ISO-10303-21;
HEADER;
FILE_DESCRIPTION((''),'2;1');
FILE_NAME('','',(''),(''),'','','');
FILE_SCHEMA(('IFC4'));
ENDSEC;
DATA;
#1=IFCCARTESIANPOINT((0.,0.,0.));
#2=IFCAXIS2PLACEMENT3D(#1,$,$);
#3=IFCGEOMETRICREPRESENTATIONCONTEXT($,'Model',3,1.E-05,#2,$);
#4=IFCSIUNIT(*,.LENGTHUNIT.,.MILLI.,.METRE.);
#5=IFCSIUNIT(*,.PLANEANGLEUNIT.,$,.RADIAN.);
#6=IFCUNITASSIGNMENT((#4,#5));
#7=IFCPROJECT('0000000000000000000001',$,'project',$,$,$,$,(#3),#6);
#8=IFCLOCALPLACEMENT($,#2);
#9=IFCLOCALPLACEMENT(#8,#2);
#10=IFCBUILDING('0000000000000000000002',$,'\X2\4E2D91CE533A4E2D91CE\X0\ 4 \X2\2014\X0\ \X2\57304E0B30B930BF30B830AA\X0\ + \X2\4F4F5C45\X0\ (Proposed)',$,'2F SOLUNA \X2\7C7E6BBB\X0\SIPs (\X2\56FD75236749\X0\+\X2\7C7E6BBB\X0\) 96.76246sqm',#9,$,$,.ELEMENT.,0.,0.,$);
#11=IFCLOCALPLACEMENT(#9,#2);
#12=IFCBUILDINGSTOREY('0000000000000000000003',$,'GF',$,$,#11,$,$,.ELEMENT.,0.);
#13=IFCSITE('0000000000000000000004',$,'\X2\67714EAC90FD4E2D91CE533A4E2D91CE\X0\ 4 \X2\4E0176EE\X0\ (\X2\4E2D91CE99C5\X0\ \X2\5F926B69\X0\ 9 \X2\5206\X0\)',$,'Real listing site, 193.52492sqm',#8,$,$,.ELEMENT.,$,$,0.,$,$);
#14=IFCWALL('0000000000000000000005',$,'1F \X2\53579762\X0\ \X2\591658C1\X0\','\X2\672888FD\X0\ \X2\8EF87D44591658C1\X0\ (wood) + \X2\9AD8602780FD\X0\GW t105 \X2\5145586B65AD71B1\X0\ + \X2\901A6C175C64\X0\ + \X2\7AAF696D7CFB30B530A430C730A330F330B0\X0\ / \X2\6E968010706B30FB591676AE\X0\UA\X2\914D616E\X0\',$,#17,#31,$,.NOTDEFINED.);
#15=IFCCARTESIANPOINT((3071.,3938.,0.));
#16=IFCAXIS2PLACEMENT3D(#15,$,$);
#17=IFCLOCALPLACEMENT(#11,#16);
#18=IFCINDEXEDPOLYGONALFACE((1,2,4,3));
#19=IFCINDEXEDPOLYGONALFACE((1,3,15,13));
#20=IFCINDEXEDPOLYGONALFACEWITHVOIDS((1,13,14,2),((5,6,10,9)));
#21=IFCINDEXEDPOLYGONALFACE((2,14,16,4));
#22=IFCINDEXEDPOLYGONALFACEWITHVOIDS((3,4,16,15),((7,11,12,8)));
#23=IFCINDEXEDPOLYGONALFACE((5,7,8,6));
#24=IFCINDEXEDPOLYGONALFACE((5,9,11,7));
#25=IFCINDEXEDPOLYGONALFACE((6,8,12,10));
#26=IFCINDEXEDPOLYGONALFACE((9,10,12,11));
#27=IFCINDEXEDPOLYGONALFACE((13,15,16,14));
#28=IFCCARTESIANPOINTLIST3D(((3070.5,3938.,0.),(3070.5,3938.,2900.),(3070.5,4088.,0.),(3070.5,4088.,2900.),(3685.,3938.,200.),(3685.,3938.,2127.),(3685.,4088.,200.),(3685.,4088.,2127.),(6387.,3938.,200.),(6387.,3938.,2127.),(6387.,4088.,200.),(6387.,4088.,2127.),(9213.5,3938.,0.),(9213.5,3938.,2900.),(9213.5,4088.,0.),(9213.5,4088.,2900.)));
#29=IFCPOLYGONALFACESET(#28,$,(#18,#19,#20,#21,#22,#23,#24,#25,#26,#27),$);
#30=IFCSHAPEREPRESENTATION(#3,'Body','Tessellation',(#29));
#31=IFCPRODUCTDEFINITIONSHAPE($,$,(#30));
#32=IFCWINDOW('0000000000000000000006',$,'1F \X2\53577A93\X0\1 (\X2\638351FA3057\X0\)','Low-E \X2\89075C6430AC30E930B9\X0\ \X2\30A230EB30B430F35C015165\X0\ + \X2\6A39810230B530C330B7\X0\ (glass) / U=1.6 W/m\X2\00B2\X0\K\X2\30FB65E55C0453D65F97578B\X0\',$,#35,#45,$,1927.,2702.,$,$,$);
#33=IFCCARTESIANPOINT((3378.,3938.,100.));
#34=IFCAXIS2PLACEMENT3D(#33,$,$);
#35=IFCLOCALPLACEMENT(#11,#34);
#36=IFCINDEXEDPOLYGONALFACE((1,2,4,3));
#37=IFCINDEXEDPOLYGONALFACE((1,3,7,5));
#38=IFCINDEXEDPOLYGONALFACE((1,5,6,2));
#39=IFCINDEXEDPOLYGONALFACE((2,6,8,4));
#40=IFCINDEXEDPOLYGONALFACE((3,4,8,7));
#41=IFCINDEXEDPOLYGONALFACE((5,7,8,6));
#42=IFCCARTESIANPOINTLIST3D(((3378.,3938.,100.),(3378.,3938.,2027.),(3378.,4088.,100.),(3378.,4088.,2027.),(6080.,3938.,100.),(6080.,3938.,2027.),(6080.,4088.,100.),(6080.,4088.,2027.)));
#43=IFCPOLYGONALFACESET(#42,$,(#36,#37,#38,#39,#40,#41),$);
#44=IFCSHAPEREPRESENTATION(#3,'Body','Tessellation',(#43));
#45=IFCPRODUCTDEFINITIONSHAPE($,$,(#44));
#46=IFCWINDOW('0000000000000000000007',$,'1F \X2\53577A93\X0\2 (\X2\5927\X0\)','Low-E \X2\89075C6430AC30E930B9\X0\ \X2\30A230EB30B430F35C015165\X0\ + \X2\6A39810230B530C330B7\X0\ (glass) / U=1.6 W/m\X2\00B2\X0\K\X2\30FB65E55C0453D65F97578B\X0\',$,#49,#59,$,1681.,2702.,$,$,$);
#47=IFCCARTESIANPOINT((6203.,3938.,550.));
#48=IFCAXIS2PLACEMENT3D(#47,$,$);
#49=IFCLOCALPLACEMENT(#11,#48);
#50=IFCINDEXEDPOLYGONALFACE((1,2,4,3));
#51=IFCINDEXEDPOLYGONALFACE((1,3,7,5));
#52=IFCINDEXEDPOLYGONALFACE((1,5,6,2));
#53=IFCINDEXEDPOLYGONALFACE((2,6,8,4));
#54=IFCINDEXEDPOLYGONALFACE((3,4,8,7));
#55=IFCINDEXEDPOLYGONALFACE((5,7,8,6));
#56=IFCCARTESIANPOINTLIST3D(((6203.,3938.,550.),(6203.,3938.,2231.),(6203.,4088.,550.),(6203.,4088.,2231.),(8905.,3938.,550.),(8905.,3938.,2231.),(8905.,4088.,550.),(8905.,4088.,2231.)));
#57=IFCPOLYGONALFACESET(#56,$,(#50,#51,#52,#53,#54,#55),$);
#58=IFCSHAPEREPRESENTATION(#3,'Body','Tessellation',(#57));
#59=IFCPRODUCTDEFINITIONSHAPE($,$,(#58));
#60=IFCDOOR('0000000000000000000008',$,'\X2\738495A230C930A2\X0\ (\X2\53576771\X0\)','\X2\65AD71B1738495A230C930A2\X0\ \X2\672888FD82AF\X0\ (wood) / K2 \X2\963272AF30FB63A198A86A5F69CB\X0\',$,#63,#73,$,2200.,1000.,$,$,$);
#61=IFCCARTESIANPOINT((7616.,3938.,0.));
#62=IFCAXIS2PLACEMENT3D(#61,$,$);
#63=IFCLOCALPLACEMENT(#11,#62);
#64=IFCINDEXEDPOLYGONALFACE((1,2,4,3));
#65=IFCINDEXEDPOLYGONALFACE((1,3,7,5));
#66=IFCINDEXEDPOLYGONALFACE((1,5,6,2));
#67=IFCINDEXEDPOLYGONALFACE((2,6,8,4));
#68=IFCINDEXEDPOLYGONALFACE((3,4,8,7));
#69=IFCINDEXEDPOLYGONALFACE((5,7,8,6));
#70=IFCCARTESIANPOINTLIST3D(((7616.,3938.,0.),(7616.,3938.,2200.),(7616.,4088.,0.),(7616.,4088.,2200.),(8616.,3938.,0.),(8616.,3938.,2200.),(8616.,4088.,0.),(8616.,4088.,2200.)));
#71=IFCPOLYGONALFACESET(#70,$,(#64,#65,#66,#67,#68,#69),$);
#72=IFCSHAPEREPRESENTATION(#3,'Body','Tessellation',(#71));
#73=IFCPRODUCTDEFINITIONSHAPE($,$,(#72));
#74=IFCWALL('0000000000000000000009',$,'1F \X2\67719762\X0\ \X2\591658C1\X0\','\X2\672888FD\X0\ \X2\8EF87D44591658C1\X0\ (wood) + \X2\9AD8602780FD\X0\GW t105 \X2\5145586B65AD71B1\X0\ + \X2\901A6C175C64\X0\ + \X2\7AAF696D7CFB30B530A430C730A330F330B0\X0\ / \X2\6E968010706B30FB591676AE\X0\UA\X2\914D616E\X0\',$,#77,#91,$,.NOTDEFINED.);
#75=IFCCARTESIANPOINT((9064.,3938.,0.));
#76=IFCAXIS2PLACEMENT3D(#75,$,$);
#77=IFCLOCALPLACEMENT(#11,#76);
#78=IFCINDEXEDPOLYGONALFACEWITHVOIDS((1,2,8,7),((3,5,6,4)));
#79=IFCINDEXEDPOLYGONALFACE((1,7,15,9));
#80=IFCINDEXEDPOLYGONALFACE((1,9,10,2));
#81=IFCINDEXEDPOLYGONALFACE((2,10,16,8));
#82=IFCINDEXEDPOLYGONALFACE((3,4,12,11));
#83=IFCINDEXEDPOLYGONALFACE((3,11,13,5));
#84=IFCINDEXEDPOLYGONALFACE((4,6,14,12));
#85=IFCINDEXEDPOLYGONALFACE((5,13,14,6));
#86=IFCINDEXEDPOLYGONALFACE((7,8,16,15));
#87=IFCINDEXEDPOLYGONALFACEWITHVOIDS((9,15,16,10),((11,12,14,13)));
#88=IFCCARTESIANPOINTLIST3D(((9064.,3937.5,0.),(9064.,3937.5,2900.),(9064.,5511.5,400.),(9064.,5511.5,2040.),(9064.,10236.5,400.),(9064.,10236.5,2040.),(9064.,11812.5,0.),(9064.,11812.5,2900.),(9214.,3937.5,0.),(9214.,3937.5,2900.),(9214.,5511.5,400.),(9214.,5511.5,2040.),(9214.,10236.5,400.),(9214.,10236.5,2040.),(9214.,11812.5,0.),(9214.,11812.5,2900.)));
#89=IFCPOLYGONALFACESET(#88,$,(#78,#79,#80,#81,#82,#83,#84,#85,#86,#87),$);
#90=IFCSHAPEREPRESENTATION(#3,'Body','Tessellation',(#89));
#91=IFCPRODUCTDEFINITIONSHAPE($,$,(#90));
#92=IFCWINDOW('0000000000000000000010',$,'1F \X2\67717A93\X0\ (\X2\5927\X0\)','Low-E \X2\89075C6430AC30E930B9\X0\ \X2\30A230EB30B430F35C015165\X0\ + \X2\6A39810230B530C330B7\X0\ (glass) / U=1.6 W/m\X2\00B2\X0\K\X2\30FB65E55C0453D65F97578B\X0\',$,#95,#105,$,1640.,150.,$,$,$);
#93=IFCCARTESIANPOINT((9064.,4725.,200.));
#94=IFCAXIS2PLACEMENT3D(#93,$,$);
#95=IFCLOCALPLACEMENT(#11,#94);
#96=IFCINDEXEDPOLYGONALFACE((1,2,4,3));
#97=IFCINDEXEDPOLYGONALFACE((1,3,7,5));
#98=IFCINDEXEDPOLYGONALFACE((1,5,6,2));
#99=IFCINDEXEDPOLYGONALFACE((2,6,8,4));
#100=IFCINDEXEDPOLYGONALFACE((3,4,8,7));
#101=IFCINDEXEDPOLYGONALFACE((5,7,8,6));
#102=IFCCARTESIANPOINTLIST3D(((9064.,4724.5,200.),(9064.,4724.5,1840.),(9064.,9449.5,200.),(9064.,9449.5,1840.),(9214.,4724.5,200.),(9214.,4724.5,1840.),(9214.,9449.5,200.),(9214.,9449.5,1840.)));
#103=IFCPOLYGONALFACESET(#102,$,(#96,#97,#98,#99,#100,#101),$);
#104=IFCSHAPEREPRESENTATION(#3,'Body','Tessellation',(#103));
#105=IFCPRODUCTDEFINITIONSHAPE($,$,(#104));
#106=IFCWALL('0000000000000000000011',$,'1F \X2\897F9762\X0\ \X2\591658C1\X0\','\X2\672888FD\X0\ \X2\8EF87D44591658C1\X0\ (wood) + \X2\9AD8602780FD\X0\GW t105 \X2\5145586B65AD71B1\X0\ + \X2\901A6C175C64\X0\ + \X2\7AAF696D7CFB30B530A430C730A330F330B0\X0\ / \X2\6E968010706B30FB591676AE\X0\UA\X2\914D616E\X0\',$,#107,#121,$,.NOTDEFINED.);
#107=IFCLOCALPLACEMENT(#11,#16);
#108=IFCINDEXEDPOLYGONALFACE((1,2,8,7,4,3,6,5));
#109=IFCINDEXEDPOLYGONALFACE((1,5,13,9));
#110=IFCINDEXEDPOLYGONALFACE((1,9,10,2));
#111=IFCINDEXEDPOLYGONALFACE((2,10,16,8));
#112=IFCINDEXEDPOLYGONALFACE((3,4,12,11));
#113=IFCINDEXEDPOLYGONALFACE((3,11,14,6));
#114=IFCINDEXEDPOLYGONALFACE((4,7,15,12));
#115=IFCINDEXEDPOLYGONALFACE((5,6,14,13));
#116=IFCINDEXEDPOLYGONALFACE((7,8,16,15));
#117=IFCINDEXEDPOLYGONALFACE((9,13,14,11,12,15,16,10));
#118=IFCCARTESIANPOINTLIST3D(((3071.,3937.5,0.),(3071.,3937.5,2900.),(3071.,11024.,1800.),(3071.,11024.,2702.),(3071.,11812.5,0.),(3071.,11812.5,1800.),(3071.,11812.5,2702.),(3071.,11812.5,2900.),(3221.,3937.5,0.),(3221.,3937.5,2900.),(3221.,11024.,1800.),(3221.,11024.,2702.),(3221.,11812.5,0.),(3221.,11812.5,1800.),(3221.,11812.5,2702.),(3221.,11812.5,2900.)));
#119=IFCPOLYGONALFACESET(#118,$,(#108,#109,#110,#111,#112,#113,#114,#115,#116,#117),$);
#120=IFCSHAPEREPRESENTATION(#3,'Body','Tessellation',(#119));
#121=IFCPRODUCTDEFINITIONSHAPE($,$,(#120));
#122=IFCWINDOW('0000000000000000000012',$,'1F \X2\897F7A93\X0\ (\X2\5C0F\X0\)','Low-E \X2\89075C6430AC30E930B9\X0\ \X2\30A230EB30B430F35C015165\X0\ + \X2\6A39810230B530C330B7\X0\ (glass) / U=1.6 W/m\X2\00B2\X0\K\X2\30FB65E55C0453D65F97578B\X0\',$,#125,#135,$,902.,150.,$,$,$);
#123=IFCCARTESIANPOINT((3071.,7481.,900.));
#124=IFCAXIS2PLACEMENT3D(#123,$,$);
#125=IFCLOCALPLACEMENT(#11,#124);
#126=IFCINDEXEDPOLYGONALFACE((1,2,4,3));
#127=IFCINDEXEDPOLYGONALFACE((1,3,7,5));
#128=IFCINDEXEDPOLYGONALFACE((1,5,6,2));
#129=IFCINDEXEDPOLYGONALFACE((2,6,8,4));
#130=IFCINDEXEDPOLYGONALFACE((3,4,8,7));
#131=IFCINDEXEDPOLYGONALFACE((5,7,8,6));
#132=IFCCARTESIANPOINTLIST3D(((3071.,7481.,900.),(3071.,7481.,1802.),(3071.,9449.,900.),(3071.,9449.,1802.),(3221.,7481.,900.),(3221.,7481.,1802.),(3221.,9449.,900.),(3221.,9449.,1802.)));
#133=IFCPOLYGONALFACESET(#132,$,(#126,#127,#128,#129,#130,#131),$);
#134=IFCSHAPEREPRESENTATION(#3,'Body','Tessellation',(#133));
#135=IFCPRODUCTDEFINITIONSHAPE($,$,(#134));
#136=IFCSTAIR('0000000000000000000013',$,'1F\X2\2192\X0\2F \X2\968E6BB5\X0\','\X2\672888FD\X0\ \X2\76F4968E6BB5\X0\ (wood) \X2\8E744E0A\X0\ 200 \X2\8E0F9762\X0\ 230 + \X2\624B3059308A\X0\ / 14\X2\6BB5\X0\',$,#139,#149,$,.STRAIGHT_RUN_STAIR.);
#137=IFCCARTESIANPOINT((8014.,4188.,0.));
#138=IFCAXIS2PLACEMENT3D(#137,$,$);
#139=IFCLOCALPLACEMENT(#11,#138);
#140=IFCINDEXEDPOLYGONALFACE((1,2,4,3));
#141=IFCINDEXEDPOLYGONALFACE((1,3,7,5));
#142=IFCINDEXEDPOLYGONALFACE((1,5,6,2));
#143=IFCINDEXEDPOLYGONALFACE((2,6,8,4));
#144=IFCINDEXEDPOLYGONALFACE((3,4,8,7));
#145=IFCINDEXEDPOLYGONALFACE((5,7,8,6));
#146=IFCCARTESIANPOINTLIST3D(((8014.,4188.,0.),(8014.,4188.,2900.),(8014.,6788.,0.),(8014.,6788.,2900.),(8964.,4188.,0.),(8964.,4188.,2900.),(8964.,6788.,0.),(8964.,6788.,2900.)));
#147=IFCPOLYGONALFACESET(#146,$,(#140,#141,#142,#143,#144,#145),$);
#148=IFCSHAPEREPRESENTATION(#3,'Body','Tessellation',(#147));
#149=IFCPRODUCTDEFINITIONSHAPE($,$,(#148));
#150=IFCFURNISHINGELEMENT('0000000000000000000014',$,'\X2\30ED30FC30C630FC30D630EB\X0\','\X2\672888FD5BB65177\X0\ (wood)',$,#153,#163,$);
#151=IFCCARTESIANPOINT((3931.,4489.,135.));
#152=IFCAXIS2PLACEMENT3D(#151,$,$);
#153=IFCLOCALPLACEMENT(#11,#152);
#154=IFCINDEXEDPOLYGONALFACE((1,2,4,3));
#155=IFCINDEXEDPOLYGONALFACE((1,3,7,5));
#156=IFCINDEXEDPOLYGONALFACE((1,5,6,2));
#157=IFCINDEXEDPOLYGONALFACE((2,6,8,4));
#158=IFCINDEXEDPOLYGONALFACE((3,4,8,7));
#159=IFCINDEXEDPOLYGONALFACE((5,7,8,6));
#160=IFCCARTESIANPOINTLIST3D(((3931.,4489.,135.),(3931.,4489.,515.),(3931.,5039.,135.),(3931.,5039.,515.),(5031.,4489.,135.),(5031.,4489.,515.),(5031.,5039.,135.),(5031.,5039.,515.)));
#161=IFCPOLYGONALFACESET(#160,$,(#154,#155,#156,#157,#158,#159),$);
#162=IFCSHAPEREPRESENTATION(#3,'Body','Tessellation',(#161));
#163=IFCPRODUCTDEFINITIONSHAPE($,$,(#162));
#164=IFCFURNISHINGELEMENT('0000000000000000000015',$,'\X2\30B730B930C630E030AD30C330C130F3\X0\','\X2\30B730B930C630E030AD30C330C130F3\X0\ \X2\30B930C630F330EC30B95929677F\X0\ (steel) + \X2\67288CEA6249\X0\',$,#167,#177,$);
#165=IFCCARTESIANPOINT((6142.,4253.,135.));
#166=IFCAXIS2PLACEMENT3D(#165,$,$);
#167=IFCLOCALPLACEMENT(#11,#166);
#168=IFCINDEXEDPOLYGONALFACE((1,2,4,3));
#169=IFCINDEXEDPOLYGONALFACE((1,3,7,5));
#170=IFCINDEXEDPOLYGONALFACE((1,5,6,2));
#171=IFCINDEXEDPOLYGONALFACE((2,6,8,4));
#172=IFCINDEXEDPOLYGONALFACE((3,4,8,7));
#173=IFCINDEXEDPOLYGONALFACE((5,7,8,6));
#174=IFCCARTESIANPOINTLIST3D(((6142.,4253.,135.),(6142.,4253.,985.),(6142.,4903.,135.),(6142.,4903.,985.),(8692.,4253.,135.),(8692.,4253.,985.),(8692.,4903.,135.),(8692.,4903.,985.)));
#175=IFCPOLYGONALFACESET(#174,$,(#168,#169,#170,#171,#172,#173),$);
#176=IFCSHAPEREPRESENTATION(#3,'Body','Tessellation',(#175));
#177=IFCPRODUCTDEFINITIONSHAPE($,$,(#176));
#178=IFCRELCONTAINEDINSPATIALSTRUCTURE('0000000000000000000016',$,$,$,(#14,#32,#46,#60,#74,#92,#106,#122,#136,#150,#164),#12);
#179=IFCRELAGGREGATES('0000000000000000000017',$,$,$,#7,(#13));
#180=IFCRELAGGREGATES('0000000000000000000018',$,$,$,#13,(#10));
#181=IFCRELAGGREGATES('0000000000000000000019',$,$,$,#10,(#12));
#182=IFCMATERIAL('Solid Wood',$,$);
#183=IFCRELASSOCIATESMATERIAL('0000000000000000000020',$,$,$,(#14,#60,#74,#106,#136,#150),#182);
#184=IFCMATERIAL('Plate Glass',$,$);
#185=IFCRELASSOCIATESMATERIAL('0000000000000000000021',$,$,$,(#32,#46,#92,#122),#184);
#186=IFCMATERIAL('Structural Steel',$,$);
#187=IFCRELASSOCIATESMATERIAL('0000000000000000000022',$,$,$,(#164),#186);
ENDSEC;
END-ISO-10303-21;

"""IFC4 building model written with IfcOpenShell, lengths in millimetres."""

from ifc_helpers import new_model, si_unit, frame, frame_2d, origin, place, context, project, spatial, rectangle, extrude, material, element, fill, save


model = new_model("IFC4")

# Units and contexts
model_context = context("Model", 3, precision=1e-05, world=origin())
ifc_project = project(units=[si_unit("LENGTHUNIT", "METRE", prefix="MILLI"), si_unit("PLANEANGLEUNIT", "RADIAN")], contexts=[model_context])

# Site, building, storey
site_placement = place(None, origin())
site = spatial("IfcSite", under=ifc_project, at=site_placement, Name="東京都中野区中野 4 丁目 (中野駅 徒歩 9 分)", ObjectType="Real listing site, 193.52492sqm", CompositionType="ELEMENT", RefElevation=0.0)
building_placement = place(site_placement, origin())
building = spatial("IfcBuilding", under=site, at=building_placement, Name="中野区中野 4 — 地下スタジオ + 住居 (Proposed)", ObjectType="2F SOLUNA 籾殻SIPs (国産杉+籾殻) 96.76246sqm", CompositionType="ELEMENT", ElevationOfRefHeight=0.0, ElevationOfTerrain=0.0)
storey_placement = place(building_placement, origin())
storey = spatial("IfcBuildingStorey", under=building, at=storey_placement, Name="GF", CompositionType="ELEMENT", Elevation=0.0)

# Shared definitions
ifc_material_1 = material(Name="Solid Wood")

# Wall, openings, windows, door
wall_1_placement = place(storey_placement, frame((3071.0, 3938.0, 0.0)))
wall_1 = element("IfcWall", 1, at=wall_1_placement, inside=storey, material=ifc_material_1, Name="1F 南面 外壁", Description="木製 軸組外壁 (wood) + 高性能GW t105 充填断熱 + 通気層 + 窯業系サイディング / 準耐火・外皮UA配慮", PredefinedType="NOTDEFINED", context=model_context, shape_type="SweptSolid", body=[
    extrude(rectangle(XDim=6143.0, YDim=150.0, at=frame_2d((3071.0, 75.0))), frame((3071.0, 3938.0, 0.0)), (0.0, 0.0, 1.0), 2900.0),
])
opening_1_placement = place(storey_placement, frame((3378.0, 3938.0, 100.0)))
opening_1 = element("IfcOpeningElement", 2, at=opening_1_placement, cuts=wall_1, PredefinedType="NOTDEFINED", context=model_context, shape_type="SweptSolid", body=[
    extrude(rectangle(XDim=2702.0, YDim=150.0, at=frame_2d((1351.0, 75.0))), frame((3378.0, 3938.0, 100.0)), (0.0, 0.0, 1.0), 1927.0),
])
opening_2_placement = place(storey_placement, frame((6203.0, 3938.0, 550.0)))
opening_2 = element("IfcOpeningElement", 3, at=opening_2_placement, cuts=wall_1, PredefinedType="NOTDEFINED", context=model_context, shape_type="SweptSolid", body=[
    extrude(rectangle(XDim=2702.0, YDim=150.0, at=frame_2d((1351.0, 75.0))), frame((6203.0, 3938.0, 550.0)), (0.0, 0.0, 1.0), 1681.0),
])
opening_3_placement = place(storey_placement, frame((7616.0, 3938.0, 0.0)))
opening_3 = element("IfcOpeningElement", 4, at=opening_3_placement, cuts=wall_1, PredefinedType="NOTDEFINED", context=model_context, shape_type="SweptSolid", body=[
    extrude(rectangle(XDim=1000.0, YDim=150.0, at=frame_2d((500.0, 75.0))), frame((7616.0, 3938.0, 0.0)), (0.0, 0.0, 1.0), 2200.0),
])
ifc_material_2 = material(Name="Plate Glass")
window_1_placement = place(storey_placement, frame((3378.0, 3938.0, 100.0)))
window_1 = element("IfcWindow", 5, at=window_1_placement, inside=storey, material=ifc_material_2, Name="1F 南窓1 (掃出し)", Description="Low-E 複層ガラス アルゴン封入 + 樹脂サッシ (glass) / U=1.6 W/m²K・日射取得型", OverallHeight=1927.0, OverallWidth=2702.0, context=model_context, shape_type="SweptSolid", body=[
    extrude(rectangle(XDim=2702.0, YDim=150.0, at=frame_2d((1351.0, 75.0))), frame((3378.0, 3938.0, 100.0)), (0.0, 0.0, 1.0), 1927.0),
])
fill(opening_1, window_1)
window_2_placement = place(storey_placement, frame((6203.0, 3938.0, 550.0)))
window_2 = element("IfcWindow", 6, at=window_2_placement, inside=storey, material=ifc_material_2, Name="1F 南窓2 (大)", Description="Low-E 複層ガラス アルゴン封入 + 樹脂サッシ (glass) / U=1.6 W/m²K・日射取得型", OverallHeight=1681.0, OverallWidth=2702.0, context=model_context, shape_type="SweptSolid", body=[
    extrude(rectangle(XDim=2702.0, YDim=150.0, at=frame_2d((1351.0, 75.0))), frame((6203.0, 3938.0, 550.0)), (0.0, 0.0, 1.0), 1681.0),
])
fill(opening_2, window_2)
door_placement = place(storey_placement, frame((7616.0, 3938.0, 0.0)))
door = element("IfcDoor", 7, at=door_placement, inside=storey, material=ifc_material_1, Name="玄関ドア (南東)", Description="断熱玄関ドア 木製芯 (wood) / K2 防犯・採風機構", OverallHeight=2200.0, OverallWidth=1000.0, context=model_context, shape_type="SweptSolid", body=[
    extrude(rectangle(XDim=1000.0, YDim=150.0, at=frame_2d((500.0, 75.0))), frame((7616.0, 3938.0, 0.0)), (0.0, 0.0, 1.0), 2200.0),
])
fill(opening_3, door)

# Walls, openings, windows
wall_2_placement = place(storey_placement, frame((9064.0, 3938.0, 0.0)))
wall_2 = element("IfcWall", 8, at=wall_2_placement, inside=storey, material=ifc_material_1, Name="1F 東面 外壁", Description="木製 軸組外壁 (wood) + 高性能GW t105 充填断熱 + 通気層 + 窯業系サイディング / 準耐火・外皮UA配慮", PredefinedType="NOTDEFINED", context=model_context, shape_type="SweptSolid", body=[
    extrude(rectangle(XDim=150.0, YDim=7875.0, at=frame_2d((75.0, 3937.0))), frame((9064.0, 3938.0, 0.0)), (0.0, 0.0, 1.0), 2900.0),
])
opening_4_placement = place(storey_placement, frame((9064.0, 4725.0, 200.0)))
opening_4 = element("IfcOpeningElement", 9, at=opening_4_placement, cuts=wall_2, PredefinedType="NOTDEFINED", context=model_context, shape_type="SweptSolid", body=[
    extrude(rectangle(XDim=150.0, YDim=4725.0, at=frame_2d((75.0, 2362.0))), frame((9064.0, 4725.0, 200.0)), (0.0, 0.0, 1.0), 1640.0),
])
window_3_placement = place(storey_placement, frame((9064.0, 4725.0, 200.0)))
window_3 = element("IfcWindow", 10, at=window_3_placement, inside=storey, material=ifc_material_2, Name="1F 東窓 (大)", Description="Low-E 複層ガラス アルゴン封入 + 樹脂サッシ (glass) / U=1.6 W/m²K・日射取得型", OverallHeight=1640.0, OverallWidth=150.0, context=model_context, shape_type="SweptSolid", body=[
    extrude(rectangle(XDim=150.0, YDim=4725.0, at=frame_2d((75.0, 2362.0))), frame((9064.0, 4725.0, 200.0)), (0.0, 0.0, 1.0), 1640.0),
])
fill(opening_4, window_3)
wall_3_placement = place(storey_placement, frame((3071.0, 3938.0, 0.0)))
wall_3 = element("IfcWall", 11, at=wall_3_placement, inside=storey, material=ifc_material_1, Name="1F 西面 外壁", Description="木製 軸組外壁 (wood) + 高性能GW t105 充填断熱 + 通気層 + 窯業系サイディング / 準耐火・外皮UA配慮", PredefinedType="NOTDEFINED", context=model_context, shape_type="SweptSolid", body=[
    extrude(rectangle(XDim=150.0, YDim=7875.0, at=frame_2d((75.0, 3937.0))), frame((3071.0, 3938.0, 0.0)), (0.0, 0.0, 1.0), 2900.0),
])
opening_5_placement = place(storey_placement, frame((3071.0, 7481.0, 900.0)))
opening_5 = element("IfcOpeningElement", 12, at=opening_5_placement, cuts=wall_3, PredefinedType="NOTDEFINED", context=model_context, shape_type="SweptSolid", body=[
    extrude(rectangle(XDim=150.0, YDim=1968.0, at=frame_2d((75.0, 984.0))), frame((3071.0, 7481.0, 900.0)), (0.0, 0.0, 1.0), 902.0),
])
window_4_placement = place(storey_placement, frame((3071.0, 7481.0, 900.0)))
window_4 = element("IfcWindow", 13, at=window_4_placement, inside=storey, material=ifc_material_2, Name="1F 西窓 (小)", Description="Low-E 複層ガラス アルゴン封入 + 樹脂サッシ (glass) / U=1.6 W/m²K・日射取得型", OverallHeight=902.0, OverallWidth=150.0, context=model_context, shape_type="SweptSolid", body=[
    extrude(rectangle(XDim=150.0, YDim=1968.0, at=frame_2d((75.0, 984.0))), frame((3071.0, 7481.0, 900.0)), (0.0, 0.0, 1.0), 902.0),
])
fill(opening_5, window_4)

# Stair
stair_placement = place(storey_placement, frame((8014.0, 4188.0, 0.0)))
element("IfcStair", 14, at=stair_placement, inside=storey, material=ifc_material_1, Name="1F→2F 階段", Description="木製 直階段 (wood) 蹴上 200 踏面 230 + 手すり / 14段", PredefinedType="STRAIGHT_RUN_STAIR", context=model_context, shape_type="SweptSolid", body=[
    extrude(rectangle(XDim=950.0, YDim=2600.0, at=frame_2d((475.0, 1300.0))), frame((8014.0, 4188.0, 0.0)), (0.0, 0.0, 1.0), 2900.0),
])

# Furnishing elements
furnishing_1_placement = place(storey_placement, frame((3931.0, 4489.0, 135.0)))
element("IfcFurnishingElement", 15, at=furnishing_1_placement, inside=storey, material=ifc_material_1, Name="ローテーブル", Description="木製家具 (wood)", context=model_context, shape_type="SweptSolid", body=[
    extrude(rectangle(XDim=1100.0, YDim=550.0, at=frame_2d((550.0, 275.0))), frame((3931.0, 4489.0, 135.0)), (0.0, 0.0, 1.0), 380.0),
])
ifc_material_3 = material(Name="Structural Steel")
furnishing_2_placement = place(storey_placement, frame((6142.0, 4253.0, 135.0)))
element("IfcFurnishingElement", 16, at=furnishing_2_placement, inside=storey, material=ifc_material_3, Name="システムキッチン", Description="システムキッチン ステンレス天板 (steel) + 木質扉", context=model_context, shape_type="SweptSolid", body=[
    extrude(rectangle(XDim=2550.0, YDim=650.0, at=frame_2d((1275.0, 325.0))), frame((6142.0, 4253.0, 135.0)), (0.0, 0.0, 1.0), 850.0),
])

save(model, "model.ifc")
